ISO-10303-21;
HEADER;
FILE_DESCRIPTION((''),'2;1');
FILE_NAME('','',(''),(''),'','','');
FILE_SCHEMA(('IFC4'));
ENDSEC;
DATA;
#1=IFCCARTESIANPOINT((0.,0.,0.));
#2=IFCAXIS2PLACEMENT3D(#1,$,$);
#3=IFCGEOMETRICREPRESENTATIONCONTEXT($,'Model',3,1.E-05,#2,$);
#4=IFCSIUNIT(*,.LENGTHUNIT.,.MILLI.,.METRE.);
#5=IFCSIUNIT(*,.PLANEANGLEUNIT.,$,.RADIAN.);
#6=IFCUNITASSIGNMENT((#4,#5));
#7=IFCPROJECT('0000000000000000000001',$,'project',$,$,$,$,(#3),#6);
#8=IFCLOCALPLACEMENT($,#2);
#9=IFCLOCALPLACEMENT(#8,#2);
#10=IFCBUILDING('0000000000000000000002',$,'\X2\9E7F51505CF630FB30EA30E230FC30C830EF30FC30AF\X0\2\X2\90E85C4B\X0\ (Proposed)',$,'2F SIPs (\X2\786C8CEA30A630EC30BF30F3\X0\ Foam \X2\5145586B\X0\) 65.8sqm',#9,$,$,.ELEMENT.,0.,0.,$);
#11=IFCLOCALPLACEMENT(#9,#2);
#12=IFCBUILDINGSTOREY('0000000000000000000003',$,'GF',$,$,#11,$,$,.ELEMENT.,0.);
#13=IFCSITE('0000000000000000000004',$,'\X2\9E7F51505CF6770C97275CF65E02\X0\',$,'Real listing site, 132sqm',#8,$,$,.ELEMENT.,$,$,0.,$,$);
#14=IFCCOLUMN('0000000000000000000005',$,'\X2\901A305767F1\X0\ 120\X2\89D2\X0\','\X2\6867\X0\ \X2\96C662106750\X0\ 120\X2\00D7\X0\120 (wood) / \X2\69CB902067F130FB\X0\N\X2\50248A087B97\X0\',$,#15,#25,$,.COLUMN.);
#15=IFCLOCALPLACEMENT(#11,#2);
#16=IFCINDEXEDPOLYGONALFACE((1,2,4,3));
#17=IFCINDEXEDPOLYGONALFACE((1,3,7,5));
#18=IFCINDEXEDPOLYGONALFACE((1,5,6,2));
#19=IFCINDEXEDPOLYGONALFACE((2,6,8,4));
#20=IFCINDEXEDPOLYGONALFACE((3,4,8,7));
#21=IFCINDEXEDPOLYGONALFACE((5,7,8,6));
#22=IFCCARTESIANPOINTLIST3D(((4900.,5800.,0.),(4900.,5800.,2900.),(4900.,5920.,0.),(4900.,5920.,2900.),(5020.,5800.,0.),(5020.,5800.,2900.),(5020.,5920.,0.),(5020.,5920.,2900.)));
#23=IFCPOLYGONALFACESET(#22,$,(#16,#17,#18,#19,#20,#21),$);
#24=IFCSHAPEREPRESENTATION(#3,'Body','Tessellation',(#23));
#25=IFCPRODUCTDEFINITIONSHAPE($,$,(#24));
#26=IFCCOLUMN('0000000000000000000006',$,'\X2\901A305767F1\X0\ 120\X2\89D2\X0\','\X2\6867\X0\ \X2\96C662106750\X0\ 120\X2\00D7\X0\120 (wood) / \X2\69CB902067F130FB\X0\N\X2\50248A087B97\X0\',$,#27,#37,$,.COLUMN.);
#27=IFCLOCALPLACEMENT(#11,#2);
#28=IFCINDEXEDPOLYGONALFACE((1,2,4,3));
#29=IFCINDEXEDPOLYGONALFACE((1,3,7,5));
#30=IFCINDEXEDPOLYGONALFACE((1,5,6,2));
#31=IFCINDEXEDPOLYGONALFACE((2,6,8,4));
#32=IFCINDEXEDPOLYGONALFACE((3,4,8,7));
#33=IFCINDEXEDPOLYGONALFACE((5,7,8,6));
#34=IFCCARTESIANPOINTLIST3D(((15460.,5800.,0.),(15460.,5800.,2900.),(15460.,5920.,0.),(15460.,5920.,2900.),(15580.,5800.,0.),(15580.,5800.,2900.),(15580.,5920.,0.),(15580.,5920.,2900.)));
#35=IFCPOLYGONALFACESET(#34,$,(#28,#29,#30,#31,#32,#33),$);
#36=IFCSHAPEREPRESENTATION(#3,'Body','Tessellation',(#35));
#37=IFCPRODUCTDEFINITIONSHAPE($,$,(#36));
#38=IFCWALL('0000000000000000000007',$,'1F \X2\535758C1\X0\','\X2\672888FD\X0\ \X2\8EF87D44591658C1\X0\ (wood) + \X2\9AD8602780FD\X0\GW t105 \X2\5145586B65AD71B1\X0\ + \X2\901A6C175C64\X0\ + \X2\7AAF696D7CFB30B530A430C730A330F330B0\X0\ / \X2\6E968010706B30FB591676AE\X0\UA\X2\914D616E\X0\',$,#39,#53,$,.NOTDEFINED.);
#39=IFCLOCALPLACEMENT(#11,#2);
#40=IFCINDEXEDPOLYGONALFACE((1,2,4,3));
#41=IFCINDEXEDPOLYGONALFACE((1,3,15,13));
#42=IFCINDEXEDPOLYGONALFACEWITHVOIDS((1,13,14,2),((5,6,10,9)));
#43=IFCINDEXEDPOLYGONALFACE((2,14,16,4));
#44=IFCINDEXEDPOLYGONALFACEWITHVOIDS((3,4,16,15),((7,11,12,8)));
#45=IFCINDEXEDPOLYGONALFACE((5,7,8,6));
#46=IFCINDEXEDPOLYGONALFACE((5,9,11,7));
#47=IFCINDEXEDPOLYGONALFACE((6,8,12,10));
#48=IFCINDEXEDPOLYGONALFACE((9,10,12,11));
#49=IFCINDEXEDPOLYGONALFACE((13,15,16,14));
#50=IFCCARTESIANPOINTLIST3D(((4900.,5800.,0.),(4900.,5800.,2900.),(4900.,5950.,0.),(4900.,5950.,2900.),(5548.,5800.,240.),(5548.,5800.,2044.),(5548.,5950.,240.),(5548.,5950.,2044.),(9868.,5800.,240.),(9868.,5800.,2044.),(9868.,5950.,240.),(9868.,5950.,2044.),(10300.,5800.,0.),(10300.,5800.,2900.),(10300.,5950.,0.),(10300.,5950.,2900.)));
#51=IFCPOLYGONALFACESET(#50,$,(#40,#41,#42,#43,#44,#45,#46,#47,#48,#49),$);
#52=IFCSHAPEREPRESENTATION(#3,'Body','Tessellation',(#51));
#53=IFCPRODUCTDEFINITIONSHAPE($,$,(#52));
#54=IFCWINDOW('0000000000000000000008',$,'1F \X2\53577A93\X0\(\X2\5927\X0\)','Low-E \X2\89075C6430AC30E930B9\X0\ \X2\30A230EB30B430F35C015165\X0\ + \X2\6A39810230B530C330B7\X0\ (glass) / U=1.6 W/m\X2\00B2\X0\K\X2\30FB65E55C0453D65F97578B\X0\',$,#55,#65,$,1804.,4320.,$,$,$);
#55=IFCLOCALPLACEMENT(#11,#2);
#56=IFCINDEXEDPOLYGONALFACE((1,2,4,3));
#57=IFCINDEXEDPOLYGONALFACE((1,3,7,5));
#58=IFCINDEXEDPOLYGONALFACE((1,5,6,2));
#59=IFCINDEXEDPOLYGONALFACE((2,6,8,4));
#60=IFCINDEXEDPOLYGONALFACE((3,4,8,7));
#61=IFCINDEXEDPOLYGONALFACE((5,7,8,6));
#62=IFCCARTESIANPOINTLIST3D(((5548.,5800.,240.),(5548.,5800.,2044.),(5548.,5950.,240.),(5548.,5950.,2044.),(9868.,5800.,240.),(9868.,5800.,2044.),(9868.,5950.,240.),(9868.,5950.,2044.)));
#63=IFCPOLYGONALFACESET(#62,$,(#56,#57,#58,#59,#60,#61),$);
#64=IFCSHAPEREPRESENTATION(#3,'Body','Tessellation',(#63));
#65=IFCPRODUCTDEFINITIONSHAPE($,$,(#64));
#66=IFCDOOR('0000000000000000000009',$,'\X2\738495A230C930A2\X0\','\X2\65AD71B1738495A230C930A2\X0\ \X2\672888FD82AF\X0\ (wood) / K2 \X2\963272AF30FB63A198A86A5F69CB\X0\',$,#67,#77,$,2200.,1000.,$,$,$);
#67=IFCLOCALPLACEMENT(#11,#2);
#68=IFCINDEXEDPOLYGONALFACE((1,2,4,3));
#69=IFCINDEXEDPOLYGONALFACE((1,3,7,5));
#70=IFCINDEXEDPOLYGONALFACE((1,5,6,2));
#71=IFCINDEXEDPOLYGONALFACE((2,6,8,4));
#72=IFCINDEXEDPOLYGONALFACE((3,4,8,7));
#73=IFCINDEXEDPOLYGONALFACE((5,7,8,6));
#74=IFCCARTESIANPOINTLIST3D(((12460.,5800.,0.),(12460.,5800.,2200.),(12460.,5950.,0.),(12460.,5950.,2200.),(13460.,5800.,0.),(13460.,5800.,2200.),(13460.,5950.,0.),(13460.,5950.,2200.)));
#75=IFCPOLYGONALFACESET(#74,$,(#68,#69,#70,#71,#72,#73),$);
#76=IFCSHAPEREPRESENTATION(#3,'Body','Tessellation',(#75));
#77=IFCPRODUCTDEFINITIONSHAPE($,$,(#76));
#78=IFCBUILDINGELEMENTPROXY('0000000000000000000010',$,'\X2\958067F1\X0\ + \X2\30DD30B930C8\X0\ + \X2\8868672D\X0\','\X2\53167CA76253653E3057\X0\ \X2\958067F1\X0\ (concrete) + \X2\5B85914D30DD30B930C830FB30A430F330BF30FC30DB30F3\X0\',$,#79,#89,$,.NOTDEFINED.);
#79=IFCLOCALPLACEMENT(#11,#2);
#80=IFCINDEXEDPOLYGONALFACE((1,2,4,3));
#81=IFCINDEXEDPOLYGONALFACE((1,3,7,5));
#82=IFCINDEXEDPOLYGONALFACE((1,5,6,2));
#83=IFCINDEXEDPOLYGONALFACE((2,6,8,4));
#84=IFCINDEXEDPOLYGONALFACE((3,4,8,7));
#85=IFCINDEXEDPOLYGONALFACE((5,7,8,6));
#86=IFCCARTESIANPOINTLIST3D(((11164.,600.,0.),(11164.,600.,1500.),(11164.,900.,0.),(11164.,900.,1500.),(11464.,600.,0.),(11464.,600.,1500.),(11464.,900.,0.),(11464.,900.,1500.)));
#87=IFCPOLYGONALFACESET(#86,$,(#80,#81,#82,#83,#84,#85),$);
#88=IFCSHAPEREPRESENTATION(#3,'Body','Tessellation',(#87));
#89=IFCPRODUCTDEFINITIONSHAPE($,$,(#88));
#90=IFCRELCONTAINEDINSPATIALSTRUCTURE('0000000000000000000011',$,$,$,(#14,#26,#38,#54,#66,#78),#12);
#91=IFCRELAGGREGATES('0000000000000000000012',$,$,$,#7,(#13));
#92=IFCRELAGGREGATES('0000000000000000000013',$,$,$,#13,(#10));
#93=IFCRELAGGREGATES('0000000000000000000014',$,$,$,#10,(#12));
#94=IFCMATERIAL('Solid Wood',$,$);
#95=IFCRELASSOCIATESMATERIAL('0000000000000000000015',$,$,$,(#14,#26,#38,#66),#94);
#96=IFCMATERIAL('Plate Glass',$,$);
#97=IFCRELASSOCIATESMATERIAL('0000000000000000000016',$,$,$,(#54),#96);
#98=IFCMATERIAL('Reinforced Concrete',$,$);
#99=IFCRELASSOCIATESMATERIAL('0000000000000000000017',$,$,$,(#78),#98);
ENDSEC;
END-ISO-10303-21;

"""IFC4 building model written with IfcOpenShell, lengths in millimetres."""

from ifc_helpers import new_model, si_unit, frame, frame_2d, origin, place, context, project, spatial, rectangle, extrude, material, element, fill, save


model = new_model("IFC4")

# Units and contexts
model_context = context("Model", 3, precision=1e-05, world=origin())
ifc_project = project(units=[si_unit("LENGTHUNIT", "METRE", prefix="MILLI"), si_unit("PLANEANGLEUNIT", "RADIAN")], contexts=[model_context])

# Site, building, storey
site_placement = place(None, origin())
site = spatial("IfcSite", under=ifc_project, at=site_placement, Name="鹿児島県霧島市", ObjectType="Real listing site, 132sqm", CompositionType="ELEMENT", RefElevation=0.0)
building_placement = place(site_placement, origin())
building = spatial("IfcBuilding", under=site, at=building_placement, Name="鹿児島・リモートワーク2部屋 (Proposed)", ObjectType="2F SIPs (硬質ウレタン Foam 充填) 65.8sqm", CompositionType="ELEMENT", ElevationOfRefHeight=0.0, ElevationOfTerrain=0.0)
storey_placement = place(building_placement, origin())
storey = spatial("IfcBuildingStorey", under=building, at=storey_placement, Name="GF", CompositionType="ELEMENT", Elevation=0.0)

# Columns
ifc_material_1 = material(Name="Solid Wood")
column_1_placement = place(storey_placement, frame((2450.0, 2900.0, 0.0)))
element("IfcColumn", 1, at=column_1_placement, inside=storey, material=ifc_material_1, Name="通し柱 120角", Description="桧 集成材 120×120 (wood) / 構造柱・N値計算", PredefinedType="COLUMN", context=model_context, shape_type="SweptSolid", body=[
    extrude(rectangle(XDim=120.0, YDim=120.0, at=frame_2d((60.0, 60.0))), frame((2450.0, 2900.0, 0.0)), (0.0, 0.0, 1.0), 2900.0),
])
column_2_placement = place(storey_placement, frame((7730.0, 2900.0, 0.0)))
element("IfcColumn", 2, at=column_2_placement, inside=storey, material=ifc_material_1, Name="通し柱 120角", Description="桧 集成材 120×120 (wood) / 構造柱・N値計算", PredefinedType="COLUMN", context=model_context, shape_type="SweptSolid", body=[
    extrude(rectangle(XDim=120.0, YDim=120.0, at=frame_2d((60.0, 60.0))), frame((7730.0, 2900.0, 0.0)), (0.0, 0.0, 1.0), 2900.0),
])

# Shared definitions
ifc_material_2 = material(Name="Reinforced Concrete")

# Wall, openings, window, door
wall_1_placement = place(storey_placement, frame((2450.0, 2900.0, 0.0)))
wall_1 = element("IfcWall", 3, at=wall_1_placement, inside=storey, material=ifc_material_1, Name="1F 南壁", Description="木製 軸組外壁 (wood) + 高性能GW t105 充填断熱 + 通気層 + 窯業系サイディング / 準耐火・外皮UA配慮", PredefinedType="NOTDEFINED", context=model_context, shape_type="SweptSolid", body=[
    extrude(rectangle(XDim=5400.0, YDim=150.0, at=frame_2d((2700.0, 75.0))), frame((2450.0, 2900.0, 0.0)), (0.0, 0.0, 1.0), 2900.0),
])
opening_1_placement = place(storey_placement, frame((2774.0, 2900.0, 120.0)))
opening_1 = element("IfcOpeningElement", 4, at=opening_1_placement, cuts=wall_1, PredefinedType="NOTDEFINED", context=model_context, shape_type="SweptSolid", body=[
    extrude(rectangle(XDim=4320.0, YDim=150.0, at=frame_2d((2160.0, 75.0))), frame((2774.0, 2900.0, 120.0)), (0.0, 0.0, 1.0), 1804.0),
])
opening_2_placement = place(storey_placement, frame((6230.0, 2900.0, 0.0)))
opening_2 = element("IfcOpeningElement", 5, at=opening_2_placement, cuts=wall_1, PredefinedType="NOTDEFINED", context=model_context, shape_type="SweptSolid", body=[
    extrude(rectangle(XDim=1000.0, YDim=150.0, at=frame_2d((500.0, 75.0))), frame((6230.0, 2900.0, 0.0)), (0.0, 0.0, 1.0), 2200.0),
])
ifc_material_3 = material(Name="Plate Glass")
window_1_placement = place(storey_placement, frame((2774.0, 2900.0, 120.0)))
window_1 = element("IfcWindow", 6, at=window_1_placement, inside=storey, material=ifc_material_3, Name="1F 南窓(大)", Description="Low-E 複層ガラス アルゴン封入 + 樹脂サッシ (glass) / U=1.6 W/m²K・日射取得型", OverallHeight=1804.0, OverallWidth=4320.0, context=model_context, shape_type="SweptSolid", body=[
    extrude(rectangle(XDim=4320.0, YDim=150.0, at=frame_2d((2160.0, 75.0))), frame((2774.0, 2900.0, 120.0)), (0.0, 0.0, 1.0), 1804.0),
])
fill(opening_1, window_1)
door_placement = place(storey_placement, frame((6230.0, 2900.0, 0.0)))
door = element("IfcDoor", 7, at=door_placement, inside=storey, material=ifc_material_1, Name="玄関ドア", Description="断熱玄関ドア 木製芯 (wood) / K2 防犯・採風機構", OverallHeight=2200.0, OverallWidth=1000.0, context=model_context, shape_type="SweptSolid", body=[
    extrude(rectangle(XDim=1000.0, YDim=150.0, at=frame_2d((500.0, 75.0))), frame((6230.0, 2900.0, 0.0)), (0.0, 0.0, 1.0), 2200.0),
])
fill(opening_2, door)

# Building element proxy
proxy_placement = place(storey_placement, frame((5582.0, 300.0, 0.0)))
element("IfcBuildingElementProxy", 8, at=proxy_placement, inside=storey, material=ifc_material_2, Name="門柱 + ポスト + 表札", Description="化粧打放し 門柱 (concrete) + 宅配ポスト・インターホン", PredefinedType="NOTDEFINED", context=model_context, shape_type="SweptSolid", body=[
    extrude(rectangle(XDim=300.0, YDim=300.0, at=frame_2d((150.0, 150.0))), frame((5582.0, 300.0, 0.0)), (0.0, 0.0, 1.0), 1500.0),
])

save(model, "model.ifc")
